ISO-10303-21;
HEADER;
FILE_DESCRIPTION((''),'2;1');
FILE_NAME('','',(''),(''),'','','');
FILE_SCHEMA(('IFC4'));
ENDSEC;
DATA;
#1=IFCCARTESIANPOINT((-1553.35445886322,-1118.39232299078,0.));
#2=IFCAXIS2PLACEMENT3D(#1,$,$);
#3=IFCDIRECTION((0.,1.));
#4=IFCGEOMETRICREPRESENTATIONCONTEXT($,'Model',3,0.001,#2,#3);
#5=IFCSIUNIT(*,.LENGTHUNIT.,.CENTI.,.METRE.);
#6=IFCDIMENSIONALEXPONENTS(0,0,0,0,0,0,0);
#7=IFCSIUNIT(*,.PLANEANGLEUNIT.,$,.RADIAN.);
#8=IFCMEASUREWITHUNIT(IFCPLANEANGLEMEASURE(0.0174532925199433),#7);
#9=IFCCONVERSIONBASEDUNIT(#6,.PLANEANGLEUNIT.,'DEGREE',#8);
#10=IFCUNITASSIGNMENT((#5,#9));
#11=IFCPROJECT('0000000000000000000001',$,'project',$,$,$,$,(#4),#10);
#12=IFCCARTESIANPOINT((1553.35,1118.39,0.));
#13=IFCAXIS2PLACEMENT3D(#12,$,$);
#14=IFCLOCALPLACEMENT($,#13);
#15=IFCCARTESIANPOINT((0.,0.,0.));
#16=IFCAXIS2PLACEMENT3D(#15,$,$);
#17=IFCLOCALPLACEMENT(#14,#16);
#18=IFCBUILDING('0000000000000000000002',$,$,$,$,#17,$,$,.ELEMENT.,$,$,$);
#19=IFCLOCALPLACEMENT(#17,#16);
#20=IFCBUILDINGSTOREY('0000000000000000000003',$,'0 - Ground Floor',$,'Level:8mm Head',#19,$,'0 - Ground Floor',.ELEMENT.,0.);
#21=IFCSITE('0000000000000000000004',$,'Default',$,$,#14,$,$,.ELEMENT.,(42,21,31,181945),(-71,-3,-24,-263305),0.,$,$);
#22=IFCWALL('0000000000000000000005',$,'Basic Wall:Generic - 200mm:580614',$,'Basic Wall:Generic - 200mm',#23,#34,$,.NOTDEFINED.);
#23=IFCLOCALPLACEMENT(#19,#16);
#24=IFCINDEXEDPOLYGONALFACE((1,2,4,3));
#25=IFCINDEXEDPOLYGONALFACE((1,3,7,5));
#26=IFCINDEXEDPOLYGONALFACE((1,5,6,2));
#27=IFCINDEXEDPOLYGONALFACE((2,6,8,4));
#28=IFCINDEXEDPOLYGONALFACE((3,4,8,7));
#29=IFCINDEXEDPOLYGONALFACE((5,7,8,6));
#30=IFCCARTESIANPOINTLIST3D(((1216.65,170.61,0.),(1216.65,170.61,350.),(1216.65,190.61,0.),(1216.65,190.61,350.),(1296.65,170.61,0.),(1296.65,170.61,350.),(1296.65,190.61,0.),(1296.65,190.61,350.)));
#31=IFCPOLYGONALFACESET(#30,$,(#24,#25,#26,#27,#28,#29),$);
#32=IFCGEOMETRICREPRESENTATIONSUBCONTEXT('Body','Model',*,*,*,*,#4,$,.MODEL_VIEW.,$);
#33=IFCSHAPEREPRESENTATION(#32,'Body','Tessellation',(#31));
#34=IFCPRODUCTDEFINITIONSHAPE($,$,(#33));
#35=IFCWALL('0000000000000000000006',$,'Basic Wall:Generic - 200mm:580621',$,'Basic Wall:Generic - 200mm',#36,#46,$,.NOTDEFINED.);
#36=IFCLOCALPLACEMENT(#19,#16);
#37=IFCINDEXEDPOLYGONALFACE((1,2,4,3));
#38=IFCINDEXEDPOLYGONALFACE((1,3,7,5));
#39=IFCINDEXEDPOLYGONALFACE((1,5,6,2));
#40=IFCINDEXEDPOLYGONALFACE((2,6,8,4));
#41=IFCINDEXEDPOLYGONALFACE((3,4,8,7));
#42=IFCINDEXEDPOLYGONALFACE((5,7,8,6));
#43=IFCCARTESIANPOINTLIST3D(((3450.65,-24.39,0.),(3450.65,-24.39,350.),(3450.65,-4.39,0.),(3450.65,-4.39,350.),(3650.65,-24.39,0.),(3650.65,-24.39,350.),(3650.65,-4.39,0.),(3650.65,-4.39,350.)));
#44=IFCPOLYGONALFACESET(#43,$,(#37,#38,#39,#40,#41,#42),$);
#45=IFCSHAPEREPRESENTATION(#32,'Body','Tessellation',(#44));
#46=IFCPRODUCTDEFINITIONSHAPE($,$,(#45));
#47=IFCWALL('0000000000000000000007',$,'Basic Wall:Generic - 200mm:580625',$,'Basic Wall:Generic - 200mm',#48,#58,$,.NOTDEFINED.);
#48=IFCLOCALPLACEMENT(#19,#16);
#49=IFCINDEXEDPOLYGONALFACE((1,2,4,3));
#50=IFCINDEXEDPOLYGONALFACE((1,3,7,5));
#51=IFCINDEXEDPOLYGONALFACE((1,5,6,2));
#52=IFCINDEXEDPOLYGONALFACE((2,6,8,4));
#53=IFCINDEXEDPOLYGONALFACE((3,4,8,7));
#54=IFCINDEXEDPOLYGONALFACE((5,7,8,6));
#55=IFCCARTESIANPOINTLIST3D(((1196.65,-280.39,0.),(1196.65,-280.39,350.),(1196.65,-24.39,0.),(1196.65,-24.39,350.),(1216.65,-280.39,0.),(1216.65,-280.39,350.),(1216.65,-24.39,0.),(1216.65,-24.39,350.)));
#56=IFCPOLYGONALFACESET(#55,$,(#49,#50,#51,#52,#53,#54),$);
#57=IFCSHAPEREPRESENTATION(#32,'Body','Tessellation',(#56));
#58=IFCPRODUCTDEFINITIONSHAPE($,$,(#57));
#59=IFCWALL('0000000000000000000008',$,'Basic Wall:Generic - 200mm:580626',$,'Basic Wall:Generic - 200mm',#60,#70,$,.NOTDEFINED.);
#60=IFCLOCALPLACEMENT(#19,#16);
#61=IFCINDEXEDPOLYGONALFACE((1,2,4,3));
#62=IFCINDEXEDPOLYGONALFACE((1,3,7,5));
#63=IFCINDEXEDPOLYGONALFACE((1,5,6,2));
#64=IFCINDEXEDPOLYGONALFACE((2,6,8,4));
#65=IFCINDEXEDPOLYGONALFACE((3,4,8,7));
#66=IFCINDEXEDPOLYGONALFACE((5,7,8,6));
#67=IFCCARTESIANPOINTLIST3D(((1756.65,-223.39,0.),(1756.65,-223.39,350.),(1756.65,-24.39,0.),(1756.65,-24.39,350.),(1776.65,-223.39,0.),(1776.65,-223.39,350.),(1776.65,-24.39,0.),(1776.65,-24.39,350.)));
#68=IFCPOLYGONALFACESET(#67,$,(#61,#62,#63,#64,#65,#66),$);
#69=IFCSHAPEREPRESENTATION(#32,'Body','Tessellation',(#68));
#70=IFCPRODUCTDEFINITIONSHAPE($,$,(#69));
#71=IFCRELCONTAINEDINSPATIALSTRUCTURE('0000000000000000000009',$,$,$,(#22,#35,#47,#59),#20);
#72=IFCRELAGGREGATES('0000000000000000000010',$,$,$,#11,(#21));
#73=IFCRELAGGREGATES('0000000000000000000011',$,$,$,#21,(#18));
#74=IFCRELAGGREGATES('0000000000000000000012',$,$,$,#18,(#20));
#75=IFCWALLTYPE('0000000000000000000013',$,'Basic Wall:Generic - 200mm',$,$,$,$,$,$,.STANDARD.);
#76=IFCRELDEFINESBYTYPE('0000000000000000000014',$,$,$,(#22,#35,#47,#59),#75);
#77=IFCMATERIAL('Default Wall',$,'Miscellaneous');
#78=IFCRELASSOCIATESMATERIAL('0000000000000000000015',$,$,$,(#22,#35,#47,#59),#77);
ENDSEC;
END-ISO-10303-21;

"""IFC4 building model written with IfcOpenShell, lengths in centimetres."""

from ifc_helpers import new_model, entity, si_unit, converted_unit, direction, frame, origin, place, context, subcontext, project, spatial, indexed_curve, outline, extrude, material, type_object, element, save


model = new_model("IFC4")

# Units and contexts
model_context = context("Model", 3, precision=0.001, world=frame((-1553.35445886322, -1118.39232299078, 0.0)), true_north=direction((0.0, 1.0)))
body_context = subcontext(model_context, "Body", "Model", "MODEL_VIEW")
ifc_project = project(units=[si_unit("LENGTHUNIT", "METRE", prefix="CENTI"), converted_unit("PLANEANGLEUNIT", "DEGREE", entity("IfcPlaneAngleMeasure", 0.0174532925199433), si_unit("PLANEANGLEUNIT", "RADIAN"), dimensions=[0, 0, 0, 0, 0, 0, 0])], contexts=[model_context])

# Site, building, storey
site_placement = place(None, frame((1553.35, 1118.39, 0.0)))
site = spatial("IfcSite", under=ifc_project, at=site_placement, Name="Default", CompositionType="ELEMENT", RefLatitude=(42, 21, 31, 181945), RefLongitude=(-71, -3, -24, -263305), RefElevation=0.0)
building_placement = place(site_placement, origin())
building = spatial("IfcBuilding", under=site, at=building_placement, CompositionType="ELEMENT")
storey_placement = place(building_placement, origin())
storey = spatial("IfcBuildingStorey", under=building, at=storey_placement, Name="0 - Ground Floor", ObjectType="Level:8mm Head", LongName="0 - Ground Floor", CompositionType="ELEMENT", Elevation=0.0)

# Walls
ifc_material_1 = material(Name="Default Wall", Category="Miscellaneous")
wall_type_1 = type_object("IfcWallType", Name="Basic Wall:Generic - 200mm", PredefinedType="STANDARD")
wall_1_placement = place(storey_placement, frame((1216.65, 180.61, 0.0)))
element("IfcWall", 1, at=wall_1_placement, inside=storey, type_object=wall_type_1, material=ifc_material_1, Name="Basic Wall:Generic - 200mm:580614", ObjectType="Basic Wall:Generic - 200mm", PredefinedType="NOTDEFINED", context=body_context, shape_type="SweptSolid", body=[
    extrude(outline(indexed_curve([(80.0, 10.0), (0.0, 10.0), (0.0, -10.0), (80.0, -10.0), (80.0, 10.0)], self_intersect=False)), origin(), (0.0, 0.0, 1.0), 350.0),
])
wall_2_placement = place(storey_placement, frame((3650.65, -14.39, 0.0), z_axis=(0.0, 0.0, 1.0), x_axis=(-1.0, 0.0, 0.0)))
element("IfcWall", 2, at=wall_2_placement, inside=storey, type_object=wall_type_1, material=ifc_material_1, Name="Basic Wall:Generic - 200mm:580621", ObjectType="Basic Wall:Generic - 200mm", PredefinedType="NOTDEFINED", context=body_context, shape_type="SweptSolid", body=[
    extrude(outline(indexed_curve([(200.0, 10.0), (0.0, 10.0), (0.0, -10.0), (200.0, -10.0), (200.0, 10.0)], self_intersect=False)), origin(), (0.0, 0.0, 1.0), 350.0),
])
wall_3_placement = place(storey_placement, frame((1206.65, -24.39, 0.0), z_axis=(0.0, 0.0, 1.0), x_axis=(0.0, -1.0, 0.0)))
element("IfcWall", 3, at=wall_3_placement, inside=storey, type_object=wall_type_1, material=ifc_material_1, Name="Basic Wall:Generic - 200mm:580625", ObjectType="Basic Wall:Generic - 200mm", PredefinedType="NOTDEFINED", context=body_context, shape_type="SweptSolid", body=[
    extrude(outline(indexed_curve([(256.0, 10.0), (0.0, 10.0), (0.0, -10.0), (256.0, -10.0), (256.0, 10.0)], self_intersect=False)), origin(), (0.0, 0.0, 1.0), 350.0),
])
wall_4_placement = place(storey_placement, frame((1766.65, -24.39, 0.0), z_axis=(0.0, 0.0, 1.0), x_axis=(0.0, -1.0, 0.0)))
element("IfcWall", 4, at=wall_4_placement, inside=storey, type_object=wall_type_1, material=ifc_material_1, Name="Basic Wall:Generic - 200mm:580626", ObjectType="Basic Wall:Generic - 200mm", PredefinedType="NOTDEFINED", context=body_context, shape_type="SweptSolid", body=[
    extrude(outline(indexed_curve([(199.0, 10.0), (0.0, 10.0), (0.0, -10.0), (199.0, -10.0), (199.0, 10.0)], self_intersect=False)), origin(), (0.0, 0.0, 1.0), 350.0),
])

save(model, "model.ifc")
